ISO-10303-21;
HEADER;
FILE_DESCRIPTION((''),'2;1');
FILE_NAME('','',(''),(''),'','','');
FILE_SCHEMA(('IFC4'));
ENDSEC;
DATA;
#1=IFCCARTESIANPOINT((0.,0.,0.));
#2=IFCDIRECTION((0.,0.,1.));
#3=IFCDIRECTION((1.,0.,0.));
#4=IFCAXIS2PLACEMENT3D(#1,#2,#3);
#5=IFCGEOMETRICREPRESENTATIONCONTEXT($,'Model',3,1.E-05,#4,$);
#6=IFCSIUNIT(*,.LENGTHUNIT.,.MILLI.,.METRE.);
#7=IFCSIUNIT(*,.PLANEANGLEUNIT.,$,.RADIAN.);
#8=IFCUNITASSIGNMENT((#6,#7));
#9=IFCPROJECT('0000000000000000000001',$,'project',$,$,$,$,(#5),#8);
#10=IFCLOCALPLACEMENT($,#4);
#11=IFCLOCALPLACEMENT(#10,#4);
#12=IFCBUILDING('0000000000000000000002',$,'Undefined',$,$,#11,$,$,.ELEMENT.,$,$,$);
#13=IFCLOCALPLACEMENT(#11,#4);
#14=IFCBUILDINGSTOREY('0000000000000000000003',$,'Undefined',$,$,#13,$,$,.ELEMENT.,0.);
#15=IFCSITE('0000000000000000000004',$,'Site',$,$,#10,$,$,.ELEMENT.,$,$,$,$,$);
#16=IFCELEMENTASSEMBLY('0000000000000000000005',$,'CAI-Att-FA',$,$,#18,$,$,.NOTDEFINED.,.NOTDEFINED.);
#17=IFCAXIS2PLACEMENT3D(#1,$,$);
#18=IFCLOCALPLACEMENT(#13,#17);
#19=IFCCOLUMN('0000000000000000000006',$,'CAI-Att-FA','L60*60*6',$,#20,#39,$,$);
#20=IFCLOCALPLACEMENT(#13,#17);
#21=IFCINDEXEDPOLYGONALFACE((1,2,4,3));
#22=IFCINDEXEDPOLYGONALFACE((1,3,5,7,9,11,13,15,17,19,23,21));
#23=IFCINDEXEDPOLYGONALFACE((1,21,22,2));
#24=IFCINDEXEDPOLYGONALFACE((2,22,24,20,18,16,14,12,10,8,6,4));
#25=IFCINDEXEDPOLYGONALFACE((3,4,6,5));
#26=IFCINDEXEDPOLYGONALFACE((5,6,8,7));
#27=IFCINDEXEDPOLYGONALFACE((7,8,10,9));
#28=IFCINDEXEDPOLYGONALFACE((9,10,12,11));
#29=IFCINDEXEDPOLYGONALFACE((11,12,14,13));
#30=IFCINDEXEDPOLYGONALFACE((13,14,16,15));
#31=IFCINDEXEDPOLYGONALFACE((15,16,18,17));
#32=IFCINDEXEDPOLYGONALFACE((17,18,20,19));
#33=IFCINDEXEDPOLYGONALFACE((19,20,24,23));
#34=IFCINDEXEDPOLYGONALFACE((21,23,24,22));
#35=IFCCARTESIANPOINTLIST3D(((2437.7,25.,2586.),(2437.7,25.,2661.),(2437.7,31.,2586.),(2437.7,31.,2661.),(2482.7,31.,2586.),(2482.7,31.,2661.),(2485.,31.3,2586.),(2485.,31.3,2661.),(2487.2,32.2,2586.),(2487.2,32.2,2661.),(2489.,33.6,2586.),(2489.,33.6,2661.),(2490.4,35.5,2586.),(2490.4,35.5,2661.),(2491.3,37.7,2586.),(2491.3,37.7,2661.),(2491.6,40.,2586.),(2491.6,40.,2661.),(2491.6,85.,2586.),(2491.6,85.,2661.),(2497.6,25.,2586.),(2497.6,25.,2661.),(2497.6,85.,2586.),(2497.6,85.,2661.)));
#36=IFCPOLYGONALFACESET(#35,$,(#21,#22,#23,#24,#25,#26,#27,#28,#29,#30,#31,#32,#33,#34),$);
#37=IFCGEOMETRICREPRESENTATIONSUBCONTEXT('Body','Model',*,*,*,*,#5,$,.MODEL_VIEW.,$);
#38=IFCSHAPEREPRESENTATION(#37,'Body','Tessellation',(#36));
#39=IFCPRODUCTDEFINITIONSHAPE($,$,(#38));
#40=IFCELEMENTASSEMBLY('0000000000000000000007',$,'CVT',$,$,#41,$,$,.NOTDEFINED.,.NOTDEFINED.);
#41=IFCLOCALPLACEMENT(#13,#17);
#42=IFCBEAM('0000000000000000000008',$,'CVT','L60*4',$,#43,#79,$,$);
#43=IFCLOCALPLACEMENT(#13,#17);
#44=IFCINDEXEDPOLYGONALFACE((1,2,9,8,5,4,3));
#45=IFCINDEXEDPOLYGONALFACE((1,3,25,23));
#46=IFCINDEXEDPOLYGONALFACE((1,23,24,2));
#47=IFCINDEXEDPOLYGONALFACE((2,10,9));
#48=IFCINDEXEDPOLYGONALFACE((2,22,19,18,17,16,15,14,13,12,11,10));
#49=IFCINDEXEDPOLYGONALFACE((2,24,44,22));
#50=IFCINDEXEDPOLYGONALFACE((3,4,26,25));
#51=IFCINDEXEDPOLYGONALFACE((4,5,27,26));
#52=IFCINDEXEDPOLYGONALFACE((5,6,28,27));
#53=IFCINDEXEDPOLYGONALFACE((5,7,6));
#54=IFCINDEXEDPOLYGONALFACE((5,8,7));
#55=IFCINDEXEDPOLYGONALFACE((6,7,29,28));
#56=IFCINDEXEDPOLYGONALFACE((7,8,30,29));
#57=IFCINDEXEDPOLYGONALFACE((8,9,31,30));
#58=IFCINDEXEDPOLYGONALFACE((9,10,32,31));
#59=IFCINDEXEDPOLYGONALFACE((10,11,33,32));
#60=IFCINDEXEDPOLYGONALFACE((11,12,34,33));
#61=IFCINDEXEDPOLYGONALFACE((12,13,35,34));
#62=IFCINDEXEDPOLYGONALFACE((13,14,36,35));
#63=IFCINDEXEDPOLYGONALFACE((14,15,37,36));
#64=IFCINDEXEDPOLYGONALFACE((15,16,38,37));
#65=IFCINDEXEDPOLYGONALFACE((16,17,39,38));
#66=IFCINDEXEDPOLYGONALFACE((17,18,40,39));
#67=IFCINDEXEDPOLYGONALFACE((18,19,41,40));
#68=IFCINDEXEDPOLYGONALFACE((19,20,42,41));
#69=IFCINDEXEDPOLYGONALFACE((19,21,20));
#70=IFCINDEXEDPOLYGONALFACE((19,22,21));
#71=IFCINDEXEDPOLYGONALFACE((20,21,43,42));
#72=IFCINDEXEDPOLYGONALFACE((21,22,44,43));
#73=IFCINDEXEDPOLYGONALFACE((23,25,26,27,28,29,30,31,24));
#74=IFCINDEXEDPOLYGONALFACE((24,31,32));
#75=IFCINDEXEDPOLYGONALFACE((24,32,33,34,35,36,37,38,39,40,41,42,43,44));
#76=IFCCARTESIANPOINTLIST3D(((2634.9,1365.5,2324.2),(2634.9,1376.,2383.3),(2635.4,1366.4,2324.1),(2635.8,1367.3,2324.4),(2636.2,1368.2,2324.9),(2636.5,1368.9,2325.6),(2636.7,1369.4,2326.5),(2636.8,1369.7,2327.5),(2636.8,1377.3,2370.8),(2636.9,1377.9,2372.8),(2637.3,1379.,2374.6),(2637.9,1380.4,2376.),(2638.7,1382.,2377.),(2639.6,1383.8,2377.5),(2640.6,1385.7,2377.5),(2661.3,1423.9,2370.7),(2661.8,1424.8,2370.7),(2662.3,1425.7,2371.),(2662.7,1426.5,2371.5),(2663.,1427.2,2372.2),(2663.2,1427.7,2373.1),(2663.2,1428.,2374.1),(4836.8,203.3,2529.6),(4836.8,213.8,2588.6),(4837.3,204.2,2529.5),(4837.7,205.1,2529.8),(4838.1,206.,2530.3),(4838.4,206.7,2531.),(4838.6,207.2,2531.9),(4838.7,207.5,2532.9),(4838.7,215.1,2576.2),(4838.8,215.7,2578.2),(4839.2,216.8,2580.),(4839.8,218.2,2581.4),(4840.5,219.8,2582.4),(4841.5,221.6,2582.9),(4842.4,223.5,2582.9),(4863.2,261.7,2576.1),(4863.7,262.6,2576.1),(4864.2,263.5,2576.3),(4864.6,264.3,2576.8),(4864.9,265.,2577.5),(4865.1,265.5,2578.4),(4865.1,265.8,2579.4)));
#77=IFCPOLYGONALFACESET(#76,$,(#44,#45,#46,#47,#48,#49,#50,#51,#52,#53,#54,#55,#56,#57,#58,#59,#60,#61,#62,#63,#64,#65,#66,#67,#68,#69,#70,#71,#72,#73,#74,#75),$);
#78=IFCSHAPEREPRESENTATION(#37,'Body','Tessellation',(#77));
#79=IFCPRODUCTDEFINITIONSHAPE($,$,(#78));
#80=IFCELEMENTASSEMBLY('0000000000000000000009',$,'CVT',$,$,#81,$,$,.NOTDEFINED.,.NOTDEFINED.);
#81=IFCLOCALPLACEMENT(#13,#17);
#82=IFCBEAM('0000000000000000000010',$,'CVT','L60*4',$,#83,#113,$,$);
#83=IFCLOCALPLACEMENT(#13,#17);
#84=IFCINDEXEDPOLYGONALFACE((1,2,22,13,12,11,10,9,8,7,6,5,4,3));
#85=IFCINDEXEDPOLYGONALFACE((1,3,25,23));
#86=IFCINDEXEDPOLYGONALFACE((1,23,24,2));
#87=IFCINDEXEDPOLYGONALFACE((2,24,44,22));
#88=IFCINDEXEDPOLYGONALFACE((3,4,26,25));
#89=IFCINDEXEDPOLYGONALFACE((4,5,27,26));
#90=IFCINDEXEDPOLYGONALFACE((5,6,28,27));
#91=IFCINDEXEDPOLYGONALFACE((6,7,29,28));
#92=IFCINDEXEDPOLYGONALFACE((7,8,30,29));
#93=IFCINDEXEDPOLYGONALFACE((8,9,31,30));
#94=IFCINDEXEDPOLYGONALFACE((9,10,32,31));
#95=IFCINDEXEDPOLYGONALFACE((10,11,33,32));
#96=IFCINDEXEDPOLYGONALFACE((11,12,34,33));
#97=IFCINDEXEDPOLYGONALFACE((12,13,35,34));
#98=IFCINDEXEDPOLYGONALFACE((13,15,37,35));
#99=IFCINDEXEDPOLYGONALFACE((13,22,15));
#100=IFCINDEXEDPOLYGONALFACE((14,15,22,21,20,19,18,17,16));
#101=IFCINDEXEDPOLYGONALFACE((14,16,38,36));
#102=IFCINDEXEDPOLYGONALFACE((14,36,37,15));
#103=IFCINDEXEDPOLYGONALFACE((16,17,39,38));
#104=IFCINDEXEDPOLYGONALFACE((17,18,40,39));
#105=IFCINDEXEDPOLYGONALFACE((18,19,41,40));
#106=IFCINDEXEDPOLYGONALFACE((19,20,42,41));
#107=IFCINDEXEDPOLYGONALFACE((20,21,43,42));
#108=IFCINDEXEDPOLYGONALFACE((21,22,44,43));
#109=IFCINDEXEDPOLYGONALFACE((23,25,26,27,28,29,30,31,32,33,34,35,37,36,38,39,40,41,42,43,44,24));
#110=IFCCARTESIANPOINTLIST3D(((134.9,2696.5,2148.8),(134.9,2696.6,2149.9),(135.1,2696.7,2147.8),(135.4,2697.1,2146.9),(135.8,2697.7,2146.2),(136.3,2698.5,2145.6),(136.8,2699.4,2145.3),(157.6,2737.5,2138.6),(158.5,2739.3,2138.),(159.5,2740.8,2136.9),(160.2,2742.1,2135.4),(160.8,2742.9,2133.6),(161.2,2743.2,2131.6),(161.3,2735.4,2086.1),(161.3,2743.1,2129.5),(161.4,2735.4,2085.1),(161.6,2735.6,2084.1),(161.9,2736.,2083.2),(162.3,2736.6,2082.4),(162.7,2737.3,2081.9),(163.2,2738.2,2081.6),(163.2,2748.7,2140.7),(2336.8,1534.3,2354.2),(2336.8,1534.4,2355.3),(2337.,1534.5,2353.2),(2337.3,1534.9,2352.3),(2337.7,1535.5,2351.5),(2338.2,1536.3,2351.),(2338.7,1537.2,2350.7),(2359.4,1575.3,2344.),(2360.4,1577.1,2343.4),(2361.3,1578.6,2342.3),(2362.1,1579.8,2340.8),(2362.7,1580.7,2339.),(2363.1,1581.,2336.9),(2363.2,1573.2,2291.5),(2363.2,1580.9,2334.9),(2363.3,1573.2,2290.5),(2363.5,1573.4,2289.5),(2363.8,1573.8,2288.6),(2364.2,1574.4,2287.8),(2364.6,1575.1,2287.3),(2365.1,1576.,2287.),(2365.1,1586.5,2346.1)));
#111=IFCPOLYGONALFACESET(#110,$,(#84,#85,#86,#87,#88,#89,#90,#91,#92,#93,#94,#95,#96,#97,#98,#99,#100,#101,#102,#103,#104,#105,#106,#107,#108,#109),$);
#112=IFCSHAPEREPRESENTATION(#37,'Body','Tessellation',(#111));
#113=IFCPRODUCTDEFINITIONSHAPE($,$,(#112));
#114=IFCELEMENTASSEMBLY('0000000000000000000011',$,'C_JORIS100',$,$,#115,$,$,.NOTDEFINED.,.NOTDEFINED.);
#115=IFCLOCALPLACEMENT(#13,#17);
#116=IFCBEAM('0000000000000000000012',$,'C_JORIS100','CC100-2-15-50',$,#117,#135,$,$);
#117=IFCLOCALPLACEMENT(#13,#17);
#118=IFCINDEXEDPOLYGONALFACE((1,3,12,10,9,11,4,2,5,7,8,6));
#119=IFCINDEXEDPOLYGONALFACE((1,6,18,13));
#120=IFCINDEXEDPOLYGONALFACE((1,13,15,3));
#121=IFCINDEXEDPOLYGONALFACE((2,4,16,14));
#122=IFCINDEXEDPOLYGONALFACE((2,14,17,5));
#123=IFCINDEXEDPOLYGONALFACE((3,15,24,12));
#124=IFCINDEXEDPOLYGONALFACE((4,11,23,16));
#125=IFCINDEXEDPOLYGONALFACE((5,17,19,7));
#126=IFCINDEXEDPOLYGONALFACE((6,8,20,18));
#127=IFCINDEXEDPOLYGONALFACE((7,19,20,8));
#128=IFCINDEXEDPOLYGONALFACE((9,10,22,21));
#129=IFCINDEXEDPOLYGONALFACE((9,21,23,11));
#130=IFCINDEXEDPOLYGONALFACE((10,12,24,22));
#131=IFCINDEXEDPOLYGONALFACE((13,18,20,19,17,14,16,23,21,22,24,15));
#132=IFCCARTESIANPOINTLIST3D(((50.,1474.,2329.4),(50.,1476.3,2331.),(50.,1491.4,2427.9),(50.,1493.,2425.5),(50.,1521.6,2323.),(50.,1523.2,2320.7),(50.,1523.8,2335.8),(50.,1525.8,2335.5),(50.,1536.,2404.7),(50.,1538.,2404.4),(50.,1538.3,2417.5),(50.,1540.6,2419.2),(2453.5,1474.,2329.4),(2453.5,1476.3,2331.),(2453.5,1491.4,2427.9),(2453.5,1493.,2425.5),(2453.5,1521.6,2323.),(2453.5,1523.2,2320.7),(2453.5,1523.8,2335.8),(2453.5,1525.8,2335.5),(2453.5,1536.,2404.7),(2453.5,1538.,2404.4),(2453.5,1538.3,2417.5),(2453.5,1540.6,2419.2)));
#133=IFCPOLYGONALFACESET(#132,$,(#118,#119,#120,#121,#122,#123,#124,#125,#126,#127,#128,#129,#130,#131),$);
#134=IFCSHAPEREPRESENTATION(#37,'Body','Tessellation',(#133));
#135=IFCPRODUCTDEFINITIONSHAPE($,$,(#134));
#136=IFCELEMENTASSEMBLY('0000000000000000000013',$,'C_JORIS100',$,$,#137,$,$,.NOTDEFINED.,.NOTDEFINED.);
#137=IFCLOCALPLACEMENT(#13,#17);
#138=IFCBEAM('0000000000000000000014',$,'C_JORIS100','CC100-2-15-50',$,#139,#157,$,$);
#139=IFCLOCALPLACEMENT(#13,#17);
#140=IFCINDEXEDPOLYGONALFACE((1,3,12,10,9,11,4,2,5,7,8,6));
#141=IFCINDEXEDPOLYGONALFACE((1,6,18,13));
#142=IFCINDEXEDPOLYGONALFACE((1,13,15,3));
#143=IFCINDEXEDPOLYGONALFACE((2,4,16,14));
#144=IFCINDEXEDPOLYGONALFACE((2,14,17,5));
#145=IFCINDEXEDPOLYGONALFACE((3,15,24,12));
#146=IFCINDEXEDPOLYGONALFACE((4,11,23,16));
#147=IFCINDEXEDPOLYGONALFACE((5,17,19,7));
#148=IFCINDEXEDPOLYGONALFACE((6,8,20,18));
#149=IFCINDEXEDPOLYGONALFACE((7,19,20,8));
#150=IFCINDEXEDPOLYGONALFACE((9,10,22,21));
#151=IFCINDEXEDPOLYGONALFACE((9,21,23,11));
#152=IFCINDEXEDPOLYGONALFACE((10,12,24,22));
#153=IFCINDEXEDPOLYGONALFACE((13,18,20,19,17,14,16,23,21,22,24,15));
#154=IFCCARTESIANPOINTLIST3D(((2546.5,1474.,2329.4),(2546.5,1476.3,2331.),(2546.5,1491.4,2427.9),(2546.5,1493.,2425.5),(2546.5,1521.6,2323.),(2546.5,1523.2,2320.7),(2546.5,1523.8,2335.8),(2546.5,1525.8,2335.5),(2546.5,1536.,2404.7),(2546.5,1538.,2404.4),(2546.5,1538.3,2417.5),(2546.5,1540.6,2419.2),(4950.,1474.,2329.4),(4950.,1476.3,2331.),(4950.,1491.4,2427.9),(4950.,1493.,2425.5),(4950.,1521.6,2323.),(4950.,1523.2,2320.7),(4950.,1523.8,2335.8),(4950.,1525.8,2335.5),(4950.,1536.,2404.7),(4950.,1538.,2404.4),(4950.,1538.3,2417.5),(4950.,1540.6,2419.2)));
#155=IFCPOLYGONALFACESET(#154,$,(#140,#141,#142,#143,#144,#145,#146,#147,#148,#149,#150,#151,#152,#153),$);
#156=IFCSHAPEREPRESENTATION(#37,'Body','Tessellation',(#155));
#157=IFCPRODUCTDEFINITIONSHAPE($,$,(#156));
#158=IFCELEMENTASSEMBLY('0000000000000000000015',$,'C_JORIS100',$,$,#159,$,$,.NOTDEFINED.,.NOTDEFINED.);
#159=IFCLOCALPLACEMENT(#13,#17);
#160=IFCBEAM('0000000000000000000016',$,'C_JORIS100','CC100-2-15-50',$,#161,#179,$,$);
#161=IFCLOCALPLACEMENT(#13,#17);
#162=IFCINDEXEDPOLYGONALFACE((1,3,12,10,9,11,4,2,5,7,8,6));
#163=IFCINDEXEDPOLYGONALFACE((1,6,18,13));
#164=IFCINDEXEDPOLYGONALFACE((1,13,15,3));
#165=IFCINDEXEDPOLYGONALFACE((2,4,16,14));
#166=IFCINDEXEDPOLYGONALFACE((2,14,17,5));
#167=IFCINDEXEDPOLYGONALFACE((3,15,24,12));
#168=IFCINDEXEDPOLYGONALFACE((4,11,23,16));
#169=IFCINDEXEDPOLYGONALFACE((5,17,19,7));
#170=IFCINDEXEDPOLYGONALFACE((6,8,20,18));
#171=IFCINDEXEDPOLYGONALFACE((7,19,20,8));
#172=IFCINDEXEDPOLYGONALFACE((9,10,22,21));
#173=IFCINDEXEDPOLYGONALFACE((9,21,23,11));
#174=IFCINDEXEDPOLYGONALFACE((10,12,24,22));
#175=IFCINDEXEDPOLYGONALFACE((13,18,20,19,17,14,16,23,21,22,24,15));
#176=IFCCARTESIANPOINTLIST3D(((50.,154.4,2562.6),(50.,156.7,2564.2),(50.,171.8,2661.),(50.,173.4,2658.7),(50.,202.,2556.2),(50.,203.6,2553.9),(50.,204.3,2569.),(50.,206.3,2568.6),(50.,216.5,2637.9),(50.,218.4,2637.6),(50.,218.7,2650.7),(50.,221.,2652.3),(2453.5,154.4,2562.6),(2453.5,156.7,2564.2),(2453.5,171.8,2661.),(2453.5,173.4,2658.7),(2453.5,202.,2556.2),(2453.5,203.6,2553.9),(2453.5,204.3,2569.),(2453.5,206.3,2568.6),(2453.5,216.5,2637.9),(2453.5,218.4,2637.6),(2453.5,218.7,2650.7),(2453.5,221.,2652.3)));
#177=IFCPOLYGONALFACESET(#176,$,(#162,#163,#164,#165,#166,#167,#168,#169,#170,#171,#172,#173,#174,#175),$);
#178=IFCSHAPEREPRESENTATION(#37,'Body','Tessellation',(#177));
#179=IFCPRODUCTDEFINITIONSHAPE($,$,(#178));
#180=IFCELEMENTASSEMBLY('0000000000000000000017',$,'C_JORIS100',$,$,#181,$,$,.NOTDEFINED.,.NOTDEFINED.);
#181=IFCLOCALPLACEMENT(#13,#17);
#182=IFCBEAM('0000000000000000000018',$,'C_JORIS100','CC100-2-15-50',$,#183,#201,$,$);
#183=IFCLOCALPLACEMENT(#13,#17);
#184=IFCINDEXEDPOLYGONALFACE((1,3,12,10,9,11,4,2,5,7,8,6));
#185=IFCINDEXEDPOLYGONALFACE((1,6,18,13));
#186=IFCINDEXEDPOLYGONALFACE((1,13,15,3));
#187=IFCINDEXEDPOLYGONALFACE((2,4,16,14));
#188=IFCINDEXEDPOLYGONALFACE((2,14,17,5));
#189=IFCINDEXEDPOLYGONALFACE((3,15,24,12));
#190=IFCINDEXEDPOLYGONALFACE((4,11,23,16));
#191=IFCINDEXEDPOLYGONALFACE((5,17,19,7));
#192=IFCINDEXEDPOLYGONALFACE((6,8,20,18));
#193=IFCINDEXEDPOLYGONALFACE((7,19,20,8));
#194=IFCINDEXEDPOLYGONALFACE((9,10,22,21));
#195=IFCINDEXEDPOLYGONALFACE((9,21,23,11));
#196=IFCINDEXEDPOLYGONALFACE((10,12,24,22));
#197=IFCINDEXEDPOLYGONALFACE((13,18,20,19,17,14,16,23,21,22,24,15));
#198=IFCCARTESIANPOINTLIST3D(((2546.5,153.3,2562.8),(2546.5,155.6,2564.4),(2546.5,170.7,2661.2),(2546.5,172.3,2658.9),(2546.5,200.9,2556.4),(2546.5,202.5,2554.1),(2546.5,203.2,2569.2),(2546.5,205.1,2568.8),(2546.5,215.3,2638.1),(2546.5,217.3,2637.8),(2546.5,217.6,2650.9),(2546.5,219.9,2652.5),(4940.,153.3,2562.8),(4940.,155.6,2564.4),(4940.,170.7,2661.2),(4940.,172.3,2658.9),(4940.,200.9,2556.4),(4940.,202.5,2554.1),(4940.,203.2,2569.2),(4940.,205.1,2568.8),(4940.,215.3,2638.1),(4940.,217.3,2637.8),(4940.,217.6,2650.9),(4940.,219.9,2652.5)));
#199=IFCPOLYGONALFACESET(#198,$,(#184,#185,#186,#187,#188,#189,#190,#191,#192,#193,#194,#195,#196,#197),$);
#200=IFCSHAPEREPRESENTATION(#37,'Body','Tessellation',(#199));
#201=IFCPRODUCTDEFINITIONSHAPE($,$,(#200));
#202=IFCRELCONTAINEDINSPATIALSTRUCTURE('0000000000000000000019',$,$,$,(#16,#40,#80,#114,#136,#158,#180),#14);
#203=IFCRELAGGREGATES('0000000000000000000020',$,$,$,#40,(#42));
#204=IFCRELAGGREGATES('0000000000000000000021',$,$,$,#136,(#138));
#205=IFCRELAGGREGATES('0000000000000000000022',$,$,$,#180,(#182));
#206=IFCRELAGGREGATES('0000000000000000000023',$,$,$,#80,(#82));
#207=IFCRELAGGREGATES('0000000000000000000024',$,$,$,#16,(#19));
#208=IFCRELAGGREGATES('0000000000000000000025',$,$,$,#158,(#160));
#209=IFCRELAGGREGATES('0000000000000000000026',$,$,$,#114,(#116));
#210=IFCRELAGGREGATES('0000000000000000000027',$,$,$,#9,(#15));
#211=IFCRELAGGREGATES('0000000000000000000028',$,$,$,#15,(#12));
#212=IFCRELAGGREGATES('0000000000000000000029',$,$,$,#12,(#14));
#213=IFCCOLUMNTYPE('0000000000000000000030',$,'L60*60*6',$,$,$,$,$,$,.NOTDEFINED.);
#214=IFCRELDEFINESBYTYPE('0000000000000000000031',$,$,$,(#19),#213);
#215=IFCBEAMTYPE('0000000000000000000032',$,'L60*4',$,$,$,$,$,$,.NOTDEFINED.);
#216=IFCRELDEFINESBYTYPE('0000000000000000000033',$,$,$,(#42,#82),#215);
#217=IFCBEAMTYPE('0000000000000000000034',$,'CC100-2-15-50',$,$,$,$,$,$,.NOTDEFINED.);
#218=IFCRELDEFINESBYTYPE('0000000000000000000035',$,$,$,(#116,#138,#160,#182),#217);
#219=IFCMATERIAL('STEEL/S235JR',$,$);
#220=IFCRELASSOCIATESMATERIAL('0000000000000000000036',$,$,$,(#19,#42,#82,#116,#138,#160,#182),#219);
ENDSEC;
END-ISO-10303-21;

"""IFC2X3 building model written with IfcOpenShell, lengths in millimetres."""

from ifc_helpers import new_model, si_unit, frame, origin_with_axes, origin_2d_with_axis, place, context, subcontext, project, spatial, l_section, c_section, extrude, clip, halfspace, material, type_object, element, aggregate, save


model = new_model("IFC2X3")

# Units and contexts
model_context = context("Model", 3, precision=1e-05, world=origin_with_axes())
body_context = subcontext(model_context, "Body", "Model", "MODEL_VIEW")
ifc_project = project(units=[si_unit("LENGTHUNIT", "METRE", prefix="MILLI"), si_unit("PLANEANGLEUNIT", "RADIAN")], contexts=[model_context])

# Site, building, storey
site_placement = place(None, origin_with_axes())
site = spatial("IfcSite", under=ifc_project, at=site_placement, Name="Site", CompositionType="ELEMENT")
building_placement = place(site_placement, origin_with_axes())
building = spatial("IfcBuilding", under=site, at=building_placement, Name="Undefined", CompositionType="ELEMENT")
storey_placement = place(building_placement, origin_with_axes())
storey = spatial("IfcBuildingStorey", under=building, at=storey_placement, Name="Undefined", CompositionType="ELEMENT", Elevation=0.0)

# Element assembly, column
assembly_1_placement = place(storey_placement, origin_with_axes())
assembly_1 = element("IfcElementAssembly", 1, at=assembly_1_placement, inside=storey, Name="CAI-Att-FA", AssemblyPlace="NOTDEFINED", PredefinedType="NOTDEFINED")
ifc_material_1 = material(Name="STEEL/S235JR")
column_type = type_object("IfcColumnType", Name="L60*60*6", PredefinedType="NOTDEFINED")
column_placement = place(assembly_1_placement, frame((2467.7, 55.0, 2586.0), z_axis=(0.0, 0.0, 1.0), x_axis=(0.0, 1.0, 0.0)))
column = element("IfcColumn", 2, at=column_placement, type_object=column_type, material=ifc_material_1, Name="CAI-Att-FA", Description="L60*60*6", context=body_context, shape_type="SweptSolid", body=[
    extrude(l_section(Depth=60.0, Width=60.0, Thickness=6.0, FilletRadius=9.0, at=origin_2d_with_axis()), frame((0.0, 0.0, 75.0), z_axis=(0.0, 0.0, -1.0), x_axis=(0.0, 1.0, 0.0)), (0.0, 0.0, 1.0), 75.0),
])

# Element assemblies, beams
beam_type_1 = type_object("IfcBeamType", Name="L60*4", PredefinedType="NOTDEFINED")
assembly_2_placement = place(storey_placement, origin_with_axes())
assembly_2 = element("IfcElementAssembly", 3, at=assembly_2_placement, inside=storey, Name="CVT", AssemblyPlace="NOTDEFINED", PredefinedType="NOTDEFINED")
beam_1_placement = place(assembly_2_placement, frame((2506.6, 1472.0, 2335.8), z_axis=(0.0, -0.174019, -0.984742), x_axis=(0.881375, -0.465209, 0.08221)))
beam_1 = element("IfcBeam", 4, at=beam_1_placement, type_object=beam_type_1, material=ifc_material_1, Name="CVT", Description="L60*4", context=body_context, shape_type="Clipping", body=[
    clip(clip(extrude(l_section(Depth=60.0, Width=60.0, Thickness=4.0, FilletRadius=8.0, EdgeRadius=4.0, at=origin_2d_with_axis()), frame((2836.5, 0.0, 0.0), z_axis=(-1.0, 0.0, 0.0), x_axis=(0.0, -1.0, 0.0)), (0.0, 0.0, 1.0), 2836.5), halfspace(frame((161.6, -30.0, -30.0), z_axis=(-1.0, -0.000054, 0.0), x_axis=(-0.000054, 1.0, 0.0)), False)), halfspace(frame((2659.9, 30.0, -30.0), z_axis=(1.0, 0.000054, 0.0), x_axis=(0.000054, -1.0, 0.0)), False)),
])
aggregate(assembly_2, [beam_1])
assembly_3_placement = place(storey_placement, origin_with_axes())
assembly_3 = element("IfcElementAssembly", 5, at=assembly_3_placement, inside=storey, Name="CVT", AssemblyPlace="NOTDEFINED", PredefinedType="NOTDEFINED")
beam_2_placement = place(assembly_3_placement, frame((-6.6, 2799.6, 2101.2), z_axis=(-0.472417, -0.867927, 0.153376), x_axis=(0.881375, -0.465209, 0.08221)))
beam_2 = element("IfcBeam", 6, at=beam_2_placement, type_object=beam_type_1, material=ifc_material_1, Name="CVT", Description="L60*4", context=body_context, shape_type="Clipping", body=[
    clip(clip(extrude(l_section(Depth=60.0, Width=60.0, Thickness=4.0, FilletRadius=8.0, EdgeRadius=4.0, at=origin_2d_with_axis()), frame((2836.5, 0.0, 0.0), z_axis=(-1.0, 0.0, 0.0), x_axis=(0.0, -1.0, 0.0)), (0.0, 0.0, 1.0), 2836.5), halfspace(frame((2674.9, -30.0, -30.0), z_axis=(1.0, 0.0, 0.0), x_axis=(0.0, 0.0, 1.0)), False)), halfspace(frame((176.6, 30.0, -30.0), z_axis=(-1.0, 0.0, -0.000054), x_axis=(-0.000054, 0.0, 1.0)), False)),
])
assembly_4_placement = place(storey_placement, origin_with_axes())
assembly_4 = element("IfcElementAssembly", 7, at=assembly_4_placement, inside=storey, Name="C_JORIS100", AssemblyPlace="NOTDEFINED", PredefinedType="NOTDEFINED")
beam_type_2 = type_object("IfcBeamType", Name="CC100-2-15-50", PredefinedType="NOTDEFINED")
beam_3_placement = place(assembly_4_placement, frame((2500.0, 1507.3, 2374.3), z_axis=(0.0, 0.174019, 0.984742), x_axis=(-1.0, 0.0, 0.0)))
beam_3 = element("IfcBeam", 8, at=beam_3_placement, type_object=beam_type_2, material=ifc_material_1, Name="C_JORIS100", Description="CC100-2-15-50", context=body_context, shape_type="Clipping", body=[
    clip(clip(extrude(c_section(Depth=100.0, Width=50.0, WallThickness=2.0, Girth=15.0, at=origin_2d_with_axis()), frame((2500.0, 0.0, 0.0), z_axis=(-1.0, 0.0, 0.0), x_axis=(0.0, -1.0, 0.0)), (0.0, 0.0, 1.0), 2500.0), halfspace(frame((2450.0, -25.0, -50.0), z_axis=(1.0, 0.0, 0.0), x_axis=(0.0, 0.0, 1.0)), False)), halfspace(frame((46.5, 25.0, -50.0), z_axis=(-1.0, 0.0, 0.0), x_axis=(0.0, 0.0, 1.0)), False)),
])
assembly_5_placement = place(storey_placement, origin_with_axes())
assembly_5 = element("IfcElementAssembly", 9, at=assembly_5_placement, inside=storey, Name="C_JORIS100", AssemblyPlace="NOTDEFINED", PredefinedType="NOTDEFINED")
beam_4_placement = place(assembly_5_placement, frame((2500.0, 1507.3, 2374.3), z_axis=(0.0, -0.174019, -0.984742), x_axis=(1.0, 0.0, 0.0)))
beam_4 = element("IfcBeam", 10, at=beam_4_placement, type_object=beam_type_2, material=ifc_material_1, Name="C_JORIS100", Description="CC100-2-15-50", context=body_context, shape_type="Clipping", body=[
    clip(clip(extrude(c_section(Depth=100.0, Width=50.0, WallThickness=2.0, Girth=15.0, at=origin_2d_with_axis()), frame((2500.0, 0.0, 0.0), z_axis=(-1.0, 0.0, 0.0), x_axis=(0.0, -1.0, 0.0)), (0.0, 0.0, 1.0), 2500.0), halfspace(frame((46.5, 25.0, -50.0), z_axis=(-1.0, 0.0, 0.0), x_axis=(0.0, 0.0, 1.0)), False)), halfspace(frame((2450.0, -25.0, -50.0), z_axis=(1.0, 0.0, 0.0), x_axis=(0.0, 0.0, 1.0)), False)),
])
aggregate(assembly_5, [beam_4])
assembly_6_placement = place(storey_placement, origin_with_axes())
assembly_6 = element("IfcElementAssembly", 11, at=assembly_6_placement, inside=storey, Name="C_JORIS100", AssemblyPlace="NOTDEFINED", PredefinedType="NOTDEFINED")
beam_5_placement = place(assembly_6_placement, frame((0.0, 187.7, 2607.5), z_axis=(0.0, -0.174019, -0.984742), x_axis=(1.0, 0.0, 0.0)))
beam_5 = element("IfcBeam", 12, at=beam_5_placement, type_object=beam_type_2, material=ifc_material_1, Name="C_JORIS100", Description="CC100-2-15-50", context=body_context, shape_type="Clipping", body=[
    clip(clip(extrude(c_section(Depth=100.0, Width=50.0, WallThickness=2.0, Girth=15.0, at=origin_2d_with_axis()), frame((2500.0, 0.0, 0.0), z_axis=(-1.0, 0.0, 0.0), x_axis=(0.0, -1.0, 0.0)), (0.0, 0.0, 1.0), 2500.0), halfspace(frame((2453.5, 23.9, 50.0), z_axis=(1.0, 0.0, 0.0), x_axis=(0.0, 0.0, -1.0)), False)), halfspace(frame((50.0, 25.0, -50.0), z_axis=(-1.0, 0.0, 0.0), x_axis=(0.0, 0.0, 1.0)), False)),
])
assembly_7_placement = place(storey_placement, origin_with_axes())
assembly_7 = element("IfcElementAssembly", 13, at=assembly_7_placement, inside=storey, Name="C_JORIS100", AssemblyPlace="NOTDEFINED", PredefinedType="NOTDEFINED")
beam_6_placement = place(assembly_7_placement, frame((2500.0, 186.6, 2607.7), z_axis=(0.0, -0.174019, -0.984742), x_axis=(1.0, 0.0, 0.0)))
beam_6 = element("IfcBeam", 14, at=beam_6_placement, type_object=beam_type_2, material=ifc_material_1, Name="C_JORIS100", Description="CC100-2-15-50", context=body_context, shape_type="Clipping", body=[
    clip(clip(extrude(c_section(Depth=100.0, Width=50.0, WallThickness=2.0, Girth=15.0, at=origin_2d_with_axis()), frame((2500.0, 0.0, 0.0), z_axis=(-1.0, 0.0, 0.0), x_axis=(0.0, -1.0, 0.0)), (0.0, 0.0, 1.0), 2500.0), halfspace(frame((2440.0, 23.0, -50.0), z_axis=(1.0, 0.0, 0.0), x_axis=(0.0, 0.0, 1.0)), False)), halfspace(frame((46.5, 22.8, -50.0), z_axis=(-1.0, 0.0, 0.0), x_axis=(0.0, 0.0, 1.0)), False)),
])
aggregate(assembly_7, [beam_6])

aggregate(assembly_3, [beam_2])
aggregate(assembly_1, [column])

aggregate(assembly_6, [beam_5])
aggregate(assembly_4, [beam_3])

save(model, "model.ifc")
